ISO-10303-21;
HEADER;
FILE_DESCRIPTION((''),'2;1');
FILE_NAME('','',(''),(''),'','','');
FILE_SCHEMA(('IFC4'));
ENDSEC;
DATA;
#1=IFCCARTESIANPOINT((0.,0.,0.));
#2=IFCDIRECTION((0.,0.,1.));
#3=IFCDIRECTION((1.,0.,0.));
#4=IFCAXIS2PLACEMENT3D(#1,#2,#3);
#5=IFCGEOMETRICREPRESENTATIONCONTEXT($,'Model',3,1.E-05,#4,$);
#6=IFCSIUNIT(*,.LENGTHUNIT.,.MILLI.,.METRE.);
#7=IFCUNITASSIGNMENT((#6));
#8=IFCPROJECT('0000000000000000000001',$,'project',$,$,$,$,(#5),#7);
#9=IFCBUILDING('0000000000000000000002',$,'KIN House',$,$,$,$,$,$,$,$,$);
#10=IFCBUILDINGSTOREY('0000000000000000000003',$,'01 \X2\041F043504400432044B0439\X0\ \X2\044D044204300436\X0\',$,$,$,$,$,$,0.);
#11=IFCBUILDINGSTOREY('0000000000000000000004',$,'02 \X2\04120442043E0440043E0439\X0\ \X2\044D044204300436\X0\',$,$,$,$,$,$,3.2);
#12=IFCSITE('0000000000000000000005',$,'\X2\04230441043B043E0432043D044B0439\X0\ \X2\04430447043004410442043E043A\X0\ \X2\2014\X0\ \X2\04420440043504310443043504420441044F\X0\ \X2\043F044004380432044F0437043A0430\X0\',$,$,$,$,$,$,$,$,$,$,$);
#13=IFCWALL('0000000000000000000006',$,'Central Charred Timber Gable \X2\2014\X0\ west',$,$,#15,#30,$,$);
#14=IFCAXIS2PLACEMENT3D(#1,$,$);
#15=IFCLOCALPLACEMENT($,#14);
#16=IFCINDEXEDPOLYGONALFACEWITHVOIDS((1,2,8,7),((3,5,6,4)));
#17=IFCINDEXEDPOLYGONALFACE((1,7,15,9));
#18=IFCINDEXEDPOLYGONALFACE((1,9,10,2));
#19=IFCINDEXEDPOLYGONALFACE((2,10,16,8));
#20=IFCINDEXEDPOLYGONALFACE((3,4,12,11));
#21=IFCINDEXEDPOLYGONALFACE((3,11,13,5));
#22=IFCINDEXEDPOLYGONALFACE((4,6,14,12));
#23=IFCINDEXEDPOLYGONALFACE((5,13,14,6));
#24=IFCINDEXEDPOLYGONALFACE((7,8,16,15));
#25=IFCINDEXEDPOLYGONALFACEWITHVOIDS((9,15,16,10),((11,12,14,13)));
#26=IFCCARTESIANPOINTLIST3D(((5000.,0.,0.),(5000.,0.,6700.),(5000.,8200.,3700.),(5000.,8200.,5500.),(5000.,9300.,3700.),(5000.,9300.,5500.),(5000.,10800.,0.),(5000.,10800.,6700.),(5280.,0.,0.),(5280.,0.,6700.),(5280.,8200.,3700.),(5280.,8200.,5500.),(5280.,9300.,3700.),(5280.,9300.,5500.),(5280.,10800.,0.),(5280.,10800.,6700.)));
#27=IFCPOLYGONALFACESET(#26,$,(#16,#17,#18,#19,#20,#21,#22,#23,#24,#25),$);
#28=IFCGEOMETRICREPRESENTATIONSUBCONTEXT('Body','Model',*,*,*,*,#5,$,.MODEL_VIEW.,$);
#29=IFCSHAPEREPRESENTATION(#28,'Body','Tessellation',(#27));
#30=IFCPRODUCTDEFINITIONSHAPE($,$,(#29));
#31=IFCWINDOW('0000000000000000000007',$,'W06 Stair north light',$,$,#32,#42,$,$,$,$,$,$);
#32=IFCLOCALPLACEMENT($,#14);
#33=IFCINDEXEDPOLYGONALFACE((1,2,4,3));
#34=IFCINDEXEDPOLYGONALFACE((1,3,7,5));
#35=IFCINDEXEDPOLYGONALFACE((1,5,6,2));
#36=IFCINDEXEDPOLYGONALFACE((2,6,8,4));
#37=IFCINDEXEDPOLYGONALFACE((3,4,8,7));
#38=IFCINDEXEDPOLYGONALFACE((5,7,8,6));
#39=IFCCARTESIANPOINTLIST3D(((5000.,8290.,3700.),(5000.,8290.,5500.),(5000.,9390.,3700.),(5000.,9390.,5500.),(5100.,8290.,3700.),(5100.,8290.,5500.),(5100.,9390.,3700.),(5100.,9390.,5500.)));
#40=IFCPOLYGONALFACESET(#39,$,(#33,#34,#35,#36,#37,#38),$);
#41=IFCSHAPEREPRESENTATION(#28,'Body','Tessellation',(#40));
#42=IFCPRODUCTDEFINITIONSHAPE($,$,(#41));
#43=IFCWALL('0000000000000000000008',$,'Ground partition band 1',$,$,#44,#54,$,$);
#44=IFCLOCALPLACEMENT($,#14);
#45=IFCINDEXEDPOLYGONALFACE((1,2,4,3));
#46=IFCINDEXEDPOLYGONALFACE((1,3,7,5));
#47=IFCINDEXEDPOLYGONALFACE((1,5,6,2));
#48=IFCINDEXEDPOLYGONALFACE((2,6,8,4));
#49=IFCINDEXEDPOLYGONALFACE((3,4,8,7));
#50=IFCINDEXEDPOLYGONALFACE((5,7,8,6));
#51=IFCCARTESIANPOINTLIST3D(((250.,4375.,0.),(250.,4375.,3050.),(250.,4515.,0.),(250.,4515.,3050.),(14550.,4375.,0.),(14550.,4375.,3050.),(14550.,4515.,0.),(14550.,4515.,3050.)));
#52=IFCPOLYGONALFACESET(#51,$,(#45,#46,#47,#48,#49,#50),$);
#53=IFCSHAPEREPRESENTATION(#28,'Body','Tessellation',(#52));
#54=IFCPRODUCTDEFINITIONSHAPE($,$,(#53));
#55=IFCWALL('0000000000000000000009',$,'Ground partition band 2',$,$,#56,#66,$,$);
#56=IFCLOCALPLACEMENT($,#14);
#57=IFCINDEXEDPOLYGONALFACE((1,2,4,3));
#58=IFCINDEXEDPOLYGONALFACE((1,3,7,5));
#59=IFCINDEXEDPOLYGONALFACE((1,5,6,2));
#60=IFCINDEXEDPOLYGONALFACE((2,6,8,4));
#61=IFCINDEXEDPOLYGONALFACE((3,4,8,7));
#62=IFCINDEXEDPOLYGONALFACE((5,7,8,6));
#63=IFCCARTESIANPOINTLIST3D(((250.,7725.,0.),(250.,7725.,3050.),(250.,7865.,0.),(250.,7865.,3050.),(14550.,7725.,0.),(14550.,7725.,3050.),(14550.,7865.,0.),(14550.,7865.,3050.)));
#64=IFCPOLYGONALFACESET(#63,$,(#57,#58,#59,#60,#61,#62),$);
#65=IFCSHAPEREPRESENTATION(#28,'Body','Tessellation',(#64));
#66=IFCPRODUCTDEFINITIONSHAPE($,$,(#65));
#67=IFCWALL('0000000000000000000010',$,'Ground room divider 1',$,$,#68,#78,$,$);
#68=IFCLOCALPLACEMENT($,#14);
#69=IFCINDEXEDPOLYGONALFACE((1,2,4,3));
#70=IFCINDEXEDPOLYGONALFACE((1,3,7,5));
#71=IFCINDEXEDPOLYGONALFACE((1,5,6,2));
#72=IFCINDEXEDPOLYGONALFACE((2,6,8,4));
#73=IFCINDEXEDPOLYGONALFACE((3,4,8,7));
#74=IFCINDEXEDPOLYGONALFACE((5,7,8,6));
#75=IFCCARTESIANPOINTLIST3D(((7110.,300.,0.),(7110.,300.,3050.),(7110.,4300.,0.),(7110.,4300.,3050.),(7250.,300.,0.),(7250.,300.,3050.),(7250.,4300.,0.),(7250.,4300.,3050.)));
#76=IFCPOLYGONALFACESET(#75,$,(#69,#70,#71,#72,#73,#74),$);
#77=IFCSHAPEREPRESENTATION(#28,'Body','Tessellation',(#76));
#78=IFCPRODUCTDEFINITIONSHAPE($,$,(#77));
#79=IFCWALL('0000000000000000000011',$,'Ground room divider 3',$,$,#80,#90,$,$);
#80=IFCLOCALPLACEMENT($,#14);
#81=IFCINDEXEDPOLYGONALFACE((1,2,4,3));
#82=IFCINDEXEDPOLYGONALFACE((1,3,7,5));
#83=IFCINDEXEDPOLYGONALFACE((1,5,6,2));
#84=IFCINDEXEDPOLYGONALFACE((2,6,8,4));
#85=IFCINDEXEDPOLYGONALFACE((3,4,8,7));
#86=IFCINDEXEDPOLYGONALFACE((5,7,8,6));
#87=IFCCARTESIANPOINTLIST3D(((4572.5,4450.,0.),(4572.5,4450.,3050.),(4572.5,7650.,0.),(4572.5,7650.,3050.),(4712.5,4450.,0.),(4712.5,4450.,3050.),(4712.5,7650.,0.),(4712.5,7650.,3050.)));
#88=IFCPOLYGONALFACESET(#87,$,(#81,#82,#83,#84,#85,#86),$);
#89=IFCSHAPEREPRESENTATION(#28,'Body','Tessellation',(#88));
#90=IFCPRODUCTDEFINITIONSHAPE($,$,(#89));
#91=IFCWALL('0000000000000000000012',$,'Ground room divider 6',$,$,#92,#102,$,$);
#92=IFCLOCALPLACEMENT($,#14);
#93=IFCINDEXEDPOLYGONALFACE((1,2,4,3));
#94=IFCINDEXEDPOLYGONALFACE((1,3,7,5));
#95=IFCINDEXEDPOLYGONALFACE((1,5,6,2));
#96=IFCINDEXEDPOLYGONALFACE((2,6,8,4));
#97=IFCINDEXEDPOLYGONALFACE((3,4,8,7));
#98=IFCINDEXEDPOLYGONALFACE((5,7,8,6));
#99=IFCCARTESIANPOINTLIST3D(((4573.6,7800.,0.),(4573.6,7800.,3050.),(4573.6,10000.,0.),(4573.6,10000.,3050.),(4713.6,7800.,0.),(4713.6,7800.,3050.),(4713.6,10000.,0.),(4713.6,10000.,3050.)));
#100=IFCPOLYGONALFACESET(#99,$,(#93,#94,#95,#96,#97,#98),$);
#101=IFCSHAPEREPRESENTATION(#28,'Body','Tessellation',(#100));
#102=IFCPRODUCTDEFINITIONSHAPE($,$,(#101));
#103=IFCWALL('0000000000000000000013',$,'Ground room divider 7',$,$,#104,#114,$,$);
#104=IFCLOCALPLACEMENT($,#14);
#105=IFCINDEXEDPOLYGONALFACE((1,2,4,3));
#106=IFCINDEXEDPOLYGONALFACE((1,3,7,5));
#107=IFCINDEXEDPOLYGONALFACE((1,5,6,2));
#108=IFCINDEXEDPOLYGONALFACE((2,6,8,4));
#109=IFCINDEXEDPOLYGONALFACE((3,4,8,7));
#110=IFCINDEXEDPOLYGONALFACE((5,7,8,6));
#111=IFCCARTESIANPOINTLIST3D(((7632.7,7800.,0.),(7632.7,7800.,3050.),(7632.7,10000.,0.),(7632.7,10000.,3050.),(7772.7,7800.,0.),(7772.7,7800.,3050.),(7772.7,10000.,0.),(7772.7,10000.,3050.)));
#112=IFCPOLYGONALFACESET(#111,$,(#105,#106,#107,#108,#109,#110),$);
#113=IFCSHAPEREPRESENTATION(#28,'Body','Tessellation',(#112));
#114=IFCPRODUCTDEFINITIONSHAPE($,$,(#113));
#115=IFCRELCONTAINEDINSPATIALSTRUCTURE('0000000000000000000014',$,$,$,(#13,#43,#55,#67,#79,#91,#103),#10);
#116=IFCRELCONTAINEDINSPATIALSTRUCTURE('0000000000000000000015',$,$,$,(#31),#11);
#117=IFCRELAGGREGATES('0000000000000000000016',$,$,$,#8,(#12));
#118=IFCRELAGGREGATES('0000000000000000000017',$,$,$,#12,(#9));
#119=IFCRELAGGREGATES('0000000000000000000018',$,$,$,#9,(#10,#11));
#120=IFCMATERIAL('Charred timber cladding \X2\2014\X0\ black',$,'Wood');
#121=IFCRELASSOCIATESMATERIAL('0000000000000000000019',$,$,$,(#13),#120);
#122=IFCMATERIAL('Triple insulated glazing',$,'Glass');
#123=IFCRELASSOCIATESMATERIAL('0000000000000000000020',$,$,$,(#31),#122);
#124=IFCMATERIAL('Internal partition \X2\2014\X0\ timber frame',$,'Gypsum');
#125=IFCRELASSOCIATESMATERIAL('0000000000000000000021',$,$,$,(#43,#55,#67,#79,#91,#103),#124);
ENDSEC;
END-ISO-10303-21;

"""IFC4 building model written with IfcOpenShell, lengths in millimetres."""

from ifc_helpers import new_model, si_unit, frame, origin_with_axes, place, context, subcontext, project, spatial, indexed_curve, outline, extrude, material, element, fill, save


model = new_model("IFC4")

# Units and contexts
model_context = context("Model", 3, precision=1e-05, world=origin_with_axes())
body_context = subcontext(model_context, "Body", "Model", "MODEL_VIEW")
ifc_project = project(units=[si_unit("LENGTHUNIT", "METRE", prefix="MILLI")], contexts=[model_context])

# Site, building, storey
site = spatial("IfcSite", under=ifc_project, Name="Условный участок — требуется привязка")
building = spatial("IfcBuilding", under=site, Name="KIN House")
storey_1 = spatial("IfcBuildingStorey", under=building, Name="01 Первый этаж", Elevation=0.0)

# Shared definitions
ifc_material_1 = material(Name="Triple insulated glazing", Category="Glass")

# Shared definitions
storey_2 = spatial("IfcBuildingStorey", under=building, Name="02 Второй этаж", Elevation=3.2)

# Shared definitions
ifc_material_2 = material(Name="Charred timber cladding — black", Category="Wood")

# Wall, opening, window
wall_1_placement = place(None, frame((5000.0, 10800.0, 0.0), z_axis=(0.0, 0.0, 1.0), x_axis=(0.0, -1.0, 0.0)))
wall_1 = element("IfcWall", 1, at=wall_1_placement, inside=storey_1, material=ifc_material_2, Name="Central Charred Timber Gable — west", context=body_context, shape_type="SweptSolid", body=[
    extrude(outline(indexed_curve([(0.0, 0.0), (0.0, 280.0), (10800.0, 280.0), (10800.0, 0.0), (0.0, 0.0)], self_intersect=False)), origin_with_axes(), (0.0, 0.0, 1.0), 6700.0),
])
opening_1_placement = place(wall_1_placement, frame((1500.0, 0.0, 3700.0), z_axis=(0.0, 0.0, 1.0), x_axis=(1.0, 0.0, 0.0)))
opening_1 = element("IfcOpeningElement", 2, at=opening_1_placement, cuts=wall_1, context=body_context, shape_type="SweptSolid", body=[
    extrude(outline(indexed_curve([(0.0, 0.0), (0.0, 380.0), (1100.0, 380.0), (1100.0, 0.0), (0.0, 0.0)], self_intersect=False)), origin_with_axes(), (0.0, 0.0, 1.0), 1800.0),
])
window_1_placement = place(None, frame((5000.0, 9390.0, 3700.0), z_axis=(0.0, 0.0, 1.0), x_axis=(0.0, -1.0, 0.0)))
window_1 = element("IfcWindow", 3, at=window_1_placement, inside=storey_2, material=ifc_material_1, Name="W06 Stair north light", context=body_context, shape_type="SweptSolid", body=[
    extrude(outline(indexed_curve([(0.0, 0.0), (0.0, 100.0), (1100.0, 100.0), (1100.0, 0.0), (0.0, 0.0)], self_intersect=False)), origin_with_axes(), (0.0, 0.0, 1.0), 1800.0),
])
fill(opening_1, window_1)

# Walls
ifc_material_3 = material(Name="Internal partition — timber frame", Category="Gypsum")
for number, where, z_axis, x_axis, name in (
    (4, (250.0, 4375.0, 0.0), (0.0, 0.0, 1.0), (1.0, 0.0, 0.0), "Ground partition band 1"),
    (5, (250.0, 7725.0, 0.0), (0.0, 0.0, 1.0), (1.0, 0.0, 0.0), "Ground partition band 2"),
):
    element("IfcWall", number, at=place(None, frame(where, z_axis=z_axis, x_axis=x_axis)), inside=storey_1, material=ifc_material_3, Name=name, context=body_context, shape_type="SweptSolid", body=[
        extrude(outline(indexed_curve([(0.0, 0.0), (0.0, 140.0), (14300.0, 140.0), (14300.0, 0.0), (0.0, 0.0)], self_intersect=False)), origin_with_axes(), (0.0, 0.0, 1.0), 3050.0),
    ])
wall_2_placement = place(None, frame((7250.0, 300.0, 0.0), z_axis=(0.0, 0.0, 1.0), x_axis=(0.0, 1.0, 0.0)))
element("IfcWall", 6, at=wall_2_placement, inside=storey_1, material=ifc_material_3, Name="Ground room divider 1", context=body_context, shape_type="SweptSolid", body=[
    extrude(outline(indexed_curve([(0.0, 0.0), (0.0, 140.0), (4000.0, 140.0), (4000.0, 0.0), (0.0, 0.0)], self_intersect=False)), origin_with_axes(), (0.0, 0.0, 1.0), 3050.0),
])
wall_3_placement = place(None, frame((4712.5, 4450.0, 0.0), z_axis=(0.0, 0.0, 1.0), x_axis=(0.0, 1.0, 0.0)))
element("IfcWall", 7, at=wall_3_placement, inside=storey_1, material=ifc_material_3, Name="Ground room divider 3", context=body_context, shape_type="SweptSolid", body=[
    extrude(outline(indexed_curve([(0.0, 0.0), (0.0, 140.0), (3200.0, 140.0), (3200.0, 0.0), (0.0, 0.0)], self_intersect=False)), origin_with_axes(), (0.0, 0.0, 1.0), 3050.0),
])
for number, where, z_axis, x_axis, name in (
    (8, (4713.6, 7800.0, 0.0), (0.0, 0.0, 1.0), (0.0, 1.0, 0.0), "Ground room divider 6"),
    (9, (7772.7, 7800.0, 0.0), (0.0, 0.0, 1.0), (0.0, 1.0, 0.0), "Ground room divider 7"),
):
    element("IfcWall", number, at=place(None, frame(where, z_axis=z_axis, x_axis=x_axis)), inside=storey_1, material=ifc_material_3, Name=name, context=body_context, shape_type="SweptSolid", body=[
        extrude(outline(indexed_curve([(0.0, 0.0), (0.0, 140.0), (2200.0, 140.0), (2200.0, 0.0), (0.0, 0.0)], self_intersect=False)), origin_with_axes(), (0.0, 0.0, 1.0), 3050.0),
    ])

save(model, "model.ifc")
